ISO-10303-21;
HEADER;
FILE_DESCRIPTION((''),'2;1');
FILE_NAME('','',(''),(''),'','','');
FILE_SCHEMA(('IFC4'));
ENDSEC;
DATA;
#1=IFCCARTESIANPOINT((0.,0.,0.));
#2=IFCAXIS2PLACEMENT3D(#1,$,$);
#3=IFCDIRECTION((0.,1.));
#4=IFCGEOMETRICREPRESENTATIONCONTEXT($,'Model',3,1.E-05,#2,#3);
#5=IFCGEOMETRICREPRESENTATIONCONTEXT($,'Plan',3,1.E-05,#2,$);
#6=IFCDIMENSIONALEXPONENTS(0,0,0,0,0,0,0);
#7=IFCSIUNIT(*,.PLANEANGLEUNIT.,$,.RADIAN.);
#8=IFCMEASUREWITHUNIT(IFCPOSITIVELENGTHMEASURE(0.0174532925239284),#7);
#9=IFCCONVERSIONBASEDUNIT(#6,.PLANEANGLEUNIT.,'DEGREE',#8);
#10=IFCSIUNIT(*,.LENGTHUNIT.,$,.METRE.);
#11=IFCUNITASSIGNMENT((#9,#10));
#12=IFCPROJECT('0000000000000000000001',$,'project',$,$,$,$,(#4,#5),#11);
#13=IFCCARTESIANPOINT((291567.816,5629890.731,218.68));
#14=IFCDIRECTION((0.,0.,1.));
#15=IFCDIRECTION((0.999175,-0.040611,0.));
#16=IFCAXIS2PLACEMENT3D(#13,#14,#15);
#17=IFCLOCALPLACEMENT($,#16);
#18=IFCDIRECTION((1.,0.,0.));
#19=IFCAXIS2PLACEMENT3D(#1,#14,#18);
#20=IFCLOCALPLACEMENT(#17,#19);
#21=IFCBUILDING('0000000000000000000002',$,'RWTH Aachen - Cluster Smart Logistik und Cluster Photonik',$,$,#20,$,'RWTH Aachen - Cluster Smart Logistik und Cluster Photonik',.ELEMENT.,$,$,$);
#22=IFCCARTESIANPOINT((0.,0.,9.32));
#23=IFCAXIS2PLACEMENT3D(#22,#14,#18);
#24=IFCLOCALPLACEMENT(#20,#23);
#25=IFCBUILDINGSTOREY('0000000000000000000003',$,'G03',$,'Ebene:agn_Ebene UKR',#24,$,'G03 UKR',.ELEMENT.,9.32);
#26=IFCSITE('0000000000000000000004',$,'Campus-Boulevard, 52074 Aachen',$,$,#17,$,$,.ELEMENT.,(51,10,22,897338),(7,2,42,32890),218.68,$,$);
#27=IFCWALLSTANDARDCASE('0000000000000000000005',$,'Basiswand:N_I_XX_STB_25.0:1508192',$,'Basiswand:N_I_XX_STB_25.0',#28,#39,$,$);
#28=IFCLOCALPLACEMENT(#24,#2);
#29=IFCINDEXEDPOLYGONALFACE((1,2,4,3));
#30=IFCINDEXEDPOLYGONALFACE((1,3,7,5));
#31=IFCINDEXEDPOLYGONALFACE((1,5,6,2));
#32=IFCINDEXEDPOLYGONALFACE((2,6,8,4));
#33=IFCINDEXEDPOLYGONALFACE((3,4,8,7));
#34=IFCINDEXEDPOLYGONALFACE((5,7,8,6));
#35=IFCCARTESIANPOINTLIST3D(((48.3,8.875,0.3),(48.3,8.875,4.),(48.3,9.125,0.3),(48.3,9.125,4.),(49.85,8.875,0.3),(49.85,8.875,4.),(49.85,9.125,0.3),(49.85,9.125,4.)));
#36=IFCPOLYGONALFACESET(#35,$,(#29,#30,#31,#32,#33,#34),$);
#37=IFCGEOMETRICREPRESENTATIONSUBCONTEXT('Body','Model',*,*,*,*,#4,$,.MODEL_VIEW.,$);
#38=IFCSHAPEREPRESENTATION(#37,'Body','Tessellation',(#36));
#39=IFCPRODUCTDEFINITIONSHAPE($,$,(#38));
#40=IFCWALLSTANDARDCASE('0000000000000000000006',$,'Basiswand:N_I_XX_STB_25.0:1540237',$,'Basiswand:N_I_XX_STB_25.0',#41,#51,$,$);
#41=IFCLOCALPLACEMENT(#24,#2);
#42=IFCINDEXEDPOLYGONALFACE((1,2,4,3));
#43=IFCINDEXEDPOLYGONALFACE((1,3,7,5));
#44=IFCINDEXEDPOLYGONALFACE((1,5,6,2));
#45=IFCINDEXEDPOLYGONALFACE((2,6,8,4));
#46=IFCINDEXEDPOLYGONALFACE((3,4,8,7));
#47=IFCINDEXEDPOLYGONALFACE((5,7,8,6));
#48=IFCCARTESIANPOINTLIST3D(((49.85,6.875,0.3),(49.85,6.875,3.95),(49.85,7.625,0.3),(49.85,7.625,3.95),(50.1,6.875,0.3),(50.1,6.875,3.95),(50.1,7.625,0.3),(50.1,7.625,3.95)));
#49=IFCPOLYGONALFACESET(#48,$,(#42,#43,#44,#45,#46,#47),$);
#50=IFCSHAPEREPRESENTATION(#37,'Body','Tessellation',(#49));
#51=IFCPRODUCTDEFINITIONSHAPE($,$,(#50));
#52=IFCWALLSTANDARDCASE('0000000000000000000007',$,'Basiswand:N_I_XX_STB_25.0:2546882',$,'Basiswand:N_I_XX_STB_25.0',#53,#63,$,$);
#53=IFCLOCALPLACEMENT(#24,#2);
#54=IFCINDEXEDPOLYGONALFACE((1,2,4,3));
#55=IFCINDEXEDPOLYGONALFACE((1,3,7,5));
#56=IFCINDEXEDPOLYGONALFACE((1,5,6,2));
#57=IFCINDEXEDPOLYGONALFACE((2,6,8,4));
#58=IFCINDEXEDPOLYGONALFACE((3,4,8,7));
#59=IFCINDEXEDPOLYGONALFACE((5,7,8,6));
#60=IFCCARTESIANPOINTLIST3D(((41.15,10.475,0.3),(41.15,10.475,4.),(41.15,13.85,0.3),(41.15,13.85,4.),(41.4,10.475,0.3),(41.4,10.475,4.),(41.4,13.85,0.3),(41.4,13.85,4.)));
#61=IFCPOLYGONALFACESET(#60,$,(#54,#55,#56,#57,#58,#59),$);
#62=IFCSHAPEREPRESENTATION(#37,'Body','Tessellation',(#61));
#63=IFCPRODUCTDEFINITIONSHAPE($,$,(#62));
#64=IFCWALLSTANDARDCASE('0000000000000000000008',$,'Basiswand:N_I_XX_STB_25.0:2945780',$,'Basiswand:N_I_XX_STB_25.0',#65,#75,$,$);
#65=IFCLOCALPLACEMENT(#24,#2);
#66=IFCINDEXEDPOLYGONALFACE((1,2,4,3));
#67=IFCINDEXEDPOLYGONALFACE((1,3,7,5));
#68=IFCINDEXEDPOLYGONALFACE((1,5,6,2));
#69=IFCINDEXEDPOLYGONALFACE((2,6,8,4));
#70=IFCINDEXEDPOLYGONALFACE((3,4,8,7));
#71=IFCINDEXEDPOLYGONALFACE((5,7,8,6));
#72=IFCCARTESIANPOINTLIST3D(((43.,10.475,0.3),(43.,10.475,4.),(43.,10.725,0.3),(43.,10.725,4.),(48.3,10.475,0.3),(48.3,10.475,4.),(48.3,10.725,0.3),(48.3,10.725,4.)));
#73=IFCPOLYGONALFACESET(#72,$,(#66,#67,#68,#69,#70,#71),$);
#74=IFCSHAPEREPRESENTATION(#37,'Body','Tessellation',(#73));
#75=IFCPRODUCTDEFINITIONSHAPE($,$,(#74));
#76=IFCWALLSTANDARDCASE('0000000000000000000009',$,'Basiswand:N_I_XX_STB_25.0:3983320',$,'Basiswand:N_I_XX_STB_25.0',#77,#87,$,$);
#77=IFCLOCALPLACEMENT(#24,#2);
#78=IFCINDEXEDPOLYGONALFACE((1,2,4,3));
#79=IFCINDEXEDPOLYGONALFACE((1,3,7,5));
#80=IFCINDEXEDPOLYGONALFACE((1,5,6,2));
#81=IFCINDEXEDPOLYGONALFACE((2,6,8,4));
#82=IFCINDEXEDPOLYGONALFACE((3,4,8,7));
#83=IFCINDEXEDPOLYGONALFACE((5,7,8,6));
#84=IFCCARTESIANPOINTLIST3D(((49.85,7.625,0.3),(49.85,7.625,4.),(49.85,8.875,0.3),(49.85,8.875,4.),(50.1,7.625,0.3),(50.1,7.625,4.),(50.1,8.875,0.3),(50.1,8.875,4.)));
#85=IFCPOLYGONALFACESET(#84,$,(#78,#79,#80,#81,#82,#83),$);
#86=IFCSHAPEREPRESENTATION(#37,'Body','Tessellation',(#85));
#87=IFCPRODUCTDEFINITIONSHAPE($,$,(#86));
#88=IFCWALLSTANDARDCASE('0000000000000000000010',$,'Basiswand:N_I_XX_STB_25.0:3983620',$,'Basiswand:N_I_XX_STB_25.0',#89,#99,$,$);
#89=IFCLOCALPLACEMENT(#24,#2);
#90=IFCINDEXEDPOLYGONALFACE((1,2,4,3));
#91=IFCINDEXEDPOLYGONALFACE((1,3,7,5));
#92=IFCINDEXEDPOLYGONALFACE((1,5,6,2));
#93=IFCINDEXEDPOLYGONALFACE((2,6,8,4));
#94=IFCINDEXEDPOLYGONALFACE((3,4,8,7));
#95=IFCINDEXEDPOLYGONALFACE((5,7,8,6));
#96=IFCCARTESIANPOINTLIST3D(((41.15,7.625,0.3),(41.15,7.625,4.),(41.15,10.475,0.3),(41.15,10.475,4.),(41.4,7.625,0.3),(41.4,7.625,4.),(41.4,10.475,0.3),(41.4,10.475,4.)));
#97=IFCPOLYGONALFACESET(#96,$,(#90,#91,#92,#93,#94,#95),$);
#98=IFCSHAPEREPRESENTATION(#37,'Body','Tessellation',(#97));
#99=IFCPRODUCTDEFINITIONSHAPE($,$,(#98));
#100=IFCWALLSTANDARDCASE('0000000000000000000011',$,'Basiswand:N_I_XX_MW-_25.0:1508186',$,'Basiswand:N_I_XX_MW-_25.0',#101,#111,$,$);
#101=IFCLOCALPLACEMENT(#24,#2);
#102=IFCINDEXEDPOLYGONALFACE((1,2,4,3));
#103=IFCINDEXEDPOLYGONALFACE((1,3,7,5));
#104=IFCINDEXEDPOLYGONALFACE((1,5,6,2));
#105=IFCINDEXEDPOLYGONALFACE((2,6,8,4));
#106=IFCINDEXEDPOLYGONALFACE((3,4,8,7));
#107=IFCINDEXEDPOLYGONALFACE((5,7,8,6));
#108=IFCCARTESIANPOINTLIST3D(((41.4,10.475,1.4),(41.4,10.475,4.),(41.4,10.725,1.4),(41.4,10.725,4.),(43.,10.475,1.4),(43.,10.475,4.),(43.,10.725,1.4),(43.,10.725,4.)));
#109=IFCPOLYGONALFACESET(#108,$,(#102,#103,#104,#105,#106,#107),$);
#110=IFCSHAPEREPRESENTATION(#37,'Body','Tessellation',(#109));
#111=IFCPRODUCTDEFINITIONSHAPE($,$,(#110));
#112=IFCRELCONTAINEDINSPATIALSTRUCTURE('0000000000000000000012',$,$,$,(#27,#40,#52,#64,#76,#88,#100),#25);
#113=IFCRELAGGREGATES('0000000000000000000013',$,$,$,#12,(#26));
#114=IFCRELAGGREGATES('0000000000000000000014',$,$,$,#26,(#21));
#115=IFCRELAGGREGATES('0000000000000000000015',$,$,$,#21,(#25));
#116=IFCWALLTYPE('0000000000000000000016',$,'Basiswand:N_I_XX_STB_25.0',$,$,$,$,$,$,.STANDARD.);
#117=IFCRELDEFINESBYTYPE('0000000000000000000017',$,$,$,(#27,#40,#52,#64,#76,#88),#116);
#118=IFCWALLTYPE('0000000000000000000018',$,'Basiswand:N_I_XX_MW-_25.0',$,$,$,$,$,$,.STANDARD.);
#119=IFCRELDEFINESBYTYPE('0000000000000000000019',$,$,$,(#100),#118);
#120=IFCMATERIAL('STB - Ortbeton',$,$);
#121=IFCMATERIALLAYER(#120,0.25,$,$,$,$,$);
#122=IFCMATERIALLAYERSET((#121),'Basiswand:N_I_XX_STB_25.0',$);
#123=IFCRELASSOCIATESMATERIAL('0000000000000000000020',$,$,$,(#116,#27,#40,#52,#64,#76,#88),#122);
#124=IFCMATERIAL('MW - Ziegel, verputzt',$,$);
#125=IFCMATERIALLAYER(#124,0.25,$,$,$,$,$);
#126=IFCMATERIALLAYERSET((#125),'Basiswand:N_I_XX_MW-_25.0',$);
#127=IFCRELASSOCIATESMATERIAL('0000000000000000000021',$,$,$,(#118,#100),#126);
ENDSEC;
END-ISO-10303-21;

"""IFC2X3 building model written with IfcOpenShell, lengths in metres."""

from ifc_helpers import new_model, entity, si_unit, converted_unit, direction, frame, frame_2d, origin, origin_with_axes, place, context, subcontext, project, spatial, rectangle, extrude, material, layer, layer_set, layer_usage, type_object, element, save


model = new_model("IFC2X3")

# Units and contexts
model_context = context("Model", 3, precision=1e-05, world=origin(), true_north=direction((0.0, 1.0)))
plan_context = context("Plan", 3, precision=1e-05, world=origin())
body_context = subcontext(model_context, "Body", "Model", "MODEL_VIEW")
ifc_project = project(units=[converted_unit("PLANEANGLEUNIT", "DEGREE", entity("IfcPositiveLengthMeasure", 0.0174532925239284), si_unit("PLANEANGLEUNIT", "RADIAN"), dimensions=[0, 0, 0, 0, 0, 0, 0]), si_unit("LENGTHUNIT", "METRE")], contexts=[model_context, plan_context])

# Site, building, storey
site_placement = place(None, frame((291567.816, 5629890.731, 218.68), z_axis=(0.0, 0.0, 1.0), x_axis=(0.999175, -0.040611, 0.0)))
site = spatial("IfcSite", under=ifc_project, at=site_placement, Name="Campus-Boulevard, 52074 Aachen", CompositionType="ELEMENT", RefLatitude=(51, 10, 22, 897338), RefLongitude=(7, 2, 42, 32890), RefElevation=218.68)
building_placement = place(site_placement, origin_with_axes())
building = spatial("IfcBuilding", under=site, at=building_placement, Name="RWTH Aachen - Cluster Smart Logistik und Cluster Photonik", LongName="RWTH Aachen - Cluster Smart Logistik und Cluster Photonik", CompositionType="ELEMENT")
storey_placement = place(building_placement, frame((0.0, 0.0, 9.32), z_axis=(0.0, 0.0, 1.0), x_axis=(1.0, 0.0, 0.0)))
storey = spatial("IfcBuildingStorey", under=building, at=storey_placement, Name="G03", ObjectType="Ebene:agn_Ebene UKR", LongName="G03 UKR", CompositionType="ELEMENT", Elevation=9.32)

# Shared definitions
ifc_material_1 = material(Name="STB - Ortbeton")

# Shared definitions
ifc_layer_1 = layer(ifc_material_1, 0.25)
ifc_layer_set_1 = layer_set([ifc_layer_1], Name="Basiswand:N_I_XX_STB_25.0")
wall_type_1 = type_object("IfcWallType", Name="Basiswand:N_I_XX_STB_25.0", PredefinedType="STANDARD", material=ifc_layer_set_1)

# Walls
ifc_layer_usage_1 = layer_usage(ifc_layer_set_1, "AXIS2", "NEGATIVE", 0.125)
wall_1_placement = place(storey_placement, frame((48.3, 9.0, 0.3), z_axis=(0.0, 0.0, 1.0), x_axis=(1.0, 0.0, 0.0)))
element("IfcWallStandardCase", 1, at=wall_1_placement, inside=storey, type_object=wall_type_1, material=ifc_layer_usage_1, Name="Basiswand:N_I_XX_STB_25.0:1508192", ObjectType="Basiswand:N_I_XX_STB_25.0", context=body_context, shape_type="SweptSolid", body=[
    extrude(rectangle(XDim=1.55, YDim=0.25, at=frame_2d((0.775, 0.0), x_axis=(-1.0, 0.0))), origin(), (0.0, 0.0, 1.0), 3.7),
])
ifc_layer_usage_2 = layer_usage(ifc_layer_set_1, "AXIS2", "POSITIVE", -0.125)
wall_2_placement = place(storey_placement, frame((49.975, 6.875, 0.3), z_axis=(0.0, 0.0, 1.0), x_axis=(0.0, 1.0, 0.0)))
element("IfcWallStandardCase", 2, at=wall_2_placement, inside=storey, type_object=wall_type_1, material=ifc_layer_usage_2, Name="Basiswand:N_I_XX_STB_25.0:1540237", ObjectType="Basiswand:N_I_XX_STB_25.0", context=body_context, shape_type="SweptSolid", body=[
    extrude(rectangle(XDim=0.75, YDim=0.25, at=frame_2d((0.375, 0.0), x_axis=(-1.0, 0.0))), origin(), (0.0, 0.0, 1.0), 3.65),
])
ifc_layer_usage_3 = layer_usage(ifc_layer_set_1, "AXIS2", "NEGATIVE", 0.125)
wall_3_placement = place(storey_placement, frame((41.275, 10.475, 0.3), z_axis=(0.0, 0.0, 1.0), x_axis=(0.0, 1.0, 0.0)))
element("IfcWallStandardCase", 3, at=wall_3_placement, inside=storey, type_object=wall_type_1, material=ifc_layer_usage_3, Name="Basiswand:N_I_XX_STB_25.0:2546882", ObjectType="Basiswand:N_I_XX_STB_25.0", context=body_context, shape_type="SweptSolid", body=[
    extrude(rectangle(XDim=3.375, YDim=0.25, at=frame_2d((1.6875, 0.0), x_axis=(-1.0, 0.0))), origin(), (0.0, 0.0, 1.0), 3.7),
])
ifc_layer_usage_4 = layer_usage(ifc_layer_set_1, "AXIS2", "NEGATIVE", 0.125)
wall_4_placement = place(storey_placement, frame((43.0, 10.6, 0.3), z_axis=(0.0, 0.0, 1.0), x_axis=(1.0, 0.0, 0.0)))
element("IfcWallStandardCase", 4, at=wall_4_placement, inside=storey, type_object=wall_type_1, material=ifc_layer_usage_4, Name="Basiswand:N_I_XX_STB_25.0:2945780", ObjectType="Basiswand:N_I_XX_STB_25.0", context=body_context, shape_type="SweptSolid", body=[
    extrude(rectangle(XDim=5.3, YDim=0.25, at=frame_2d((2.65, 0.0), x_axis=(-1.0, 0.0))), origin(), (0.0, 0.0, 1.0), 3.7),
])
ifc_layer_usage_5 = layer_usage(ifc_layer_set_1, "AXIS2", "POSITIVE", -0.125)
wall_5_placement = place(storey_placement, frame((49.975, 7.625, 0.3), z_axis=(0.0, 0.0, 1.0), x_axis=(0.0, 1.0, 0.0)))
element("IfcWallStandardCase", 5, at=wall_5_placement, inside=storey, type_object=wall_type_1, material=ifc_layer_usage_5, Name="Basiswand:N_I_XX_STB_25.0:3983320", ObjectType="Basiswand:N_I_XX_STB_25.0", context=body_context, shape_type="SweptSolid", body=[
    extrude(rectangle(XDim=1.25, YDim=0.25, at=frame_2d((0.625, 0.0), x_axis=(-1.0, 0.0))), origin(), (0.0, 0.0, 1.0), 3.7),
])
ifc_layer_usage_6 = layer_usage(ifc_layer_set_1, "AXIS2", "NEGATIVE", 0.125)
wall_6_placement = place(storey_placement, frame((41.275, 7.625, 0.3), z_axis=(0.0, 0.0, 1.0), x_axis=(0.0, 1.0, 0.0)))
element("IfcWallStandardCase", 6, at=wall_6_placement, inside=storey, type_object=wall_type_1, material=ifc_layer_usage_6, Name="Basiswand:N_I_XX_STB_25.0:3983620", ObjectType="Basiswand:N_I_XX_STB_25.0", context=body_context, shape_type="SweptSolid", body=[
    extrude(rectangle(XDim=2.85, YDim=0.25, at=frame_2d((1.425, 0.0), x_axis=(-1.0, 0.0))), origin(), (0.0, 0.0, 1.0), 3.7),
])
ifc_material_2 = material(Name="MW - Ziegel, verputzt")
ifc_layer_2 = layer(ifc_material_2, 0.25)
ifc_layer_set_2 = layer_set([ifc_layer_2], Name="Basiswand:N_I_XX_MW-_25.0")
ifc_layer_usage_7 = layer_usage(ifc_layer_set_2, "AXIS2", "NEGATIVE", 0.125)
wall_type_2 = type_object("IfcWallType", Name="Basiswand:N_I_XX_MW-_25.0", PredefinedType="STANDARD", material=ifc_layer_set_2)
wall_7_placement = place(storey_placement, frame((41.4, 10.6, 1.4), z_axis=(0.0, 0.0, 1.0), x_axis=(1.0, 0.0, 0.0)))
element("IfcWallStandardCase", 7, at=wall_7_placement, inside=storey, type_object=wall_type_2, material=ifc_layer_usage_7, Name="Basiswand:N_I_XX_MW-_25.0:1508186", ObjectType="Basiswand:N_I_XX_MW-_25.0", context=body_context, shape_type="SweptSolid", body=[
    extrude(rectangle(XDim=1.6, YDim=0.25, at=frame_2d((0.8, 0.0), x_axis=(-1.0, 0.0))), origin(), (0.0, 0.0, 1.0), 2.6),
])

save(model, "model.ifc")
